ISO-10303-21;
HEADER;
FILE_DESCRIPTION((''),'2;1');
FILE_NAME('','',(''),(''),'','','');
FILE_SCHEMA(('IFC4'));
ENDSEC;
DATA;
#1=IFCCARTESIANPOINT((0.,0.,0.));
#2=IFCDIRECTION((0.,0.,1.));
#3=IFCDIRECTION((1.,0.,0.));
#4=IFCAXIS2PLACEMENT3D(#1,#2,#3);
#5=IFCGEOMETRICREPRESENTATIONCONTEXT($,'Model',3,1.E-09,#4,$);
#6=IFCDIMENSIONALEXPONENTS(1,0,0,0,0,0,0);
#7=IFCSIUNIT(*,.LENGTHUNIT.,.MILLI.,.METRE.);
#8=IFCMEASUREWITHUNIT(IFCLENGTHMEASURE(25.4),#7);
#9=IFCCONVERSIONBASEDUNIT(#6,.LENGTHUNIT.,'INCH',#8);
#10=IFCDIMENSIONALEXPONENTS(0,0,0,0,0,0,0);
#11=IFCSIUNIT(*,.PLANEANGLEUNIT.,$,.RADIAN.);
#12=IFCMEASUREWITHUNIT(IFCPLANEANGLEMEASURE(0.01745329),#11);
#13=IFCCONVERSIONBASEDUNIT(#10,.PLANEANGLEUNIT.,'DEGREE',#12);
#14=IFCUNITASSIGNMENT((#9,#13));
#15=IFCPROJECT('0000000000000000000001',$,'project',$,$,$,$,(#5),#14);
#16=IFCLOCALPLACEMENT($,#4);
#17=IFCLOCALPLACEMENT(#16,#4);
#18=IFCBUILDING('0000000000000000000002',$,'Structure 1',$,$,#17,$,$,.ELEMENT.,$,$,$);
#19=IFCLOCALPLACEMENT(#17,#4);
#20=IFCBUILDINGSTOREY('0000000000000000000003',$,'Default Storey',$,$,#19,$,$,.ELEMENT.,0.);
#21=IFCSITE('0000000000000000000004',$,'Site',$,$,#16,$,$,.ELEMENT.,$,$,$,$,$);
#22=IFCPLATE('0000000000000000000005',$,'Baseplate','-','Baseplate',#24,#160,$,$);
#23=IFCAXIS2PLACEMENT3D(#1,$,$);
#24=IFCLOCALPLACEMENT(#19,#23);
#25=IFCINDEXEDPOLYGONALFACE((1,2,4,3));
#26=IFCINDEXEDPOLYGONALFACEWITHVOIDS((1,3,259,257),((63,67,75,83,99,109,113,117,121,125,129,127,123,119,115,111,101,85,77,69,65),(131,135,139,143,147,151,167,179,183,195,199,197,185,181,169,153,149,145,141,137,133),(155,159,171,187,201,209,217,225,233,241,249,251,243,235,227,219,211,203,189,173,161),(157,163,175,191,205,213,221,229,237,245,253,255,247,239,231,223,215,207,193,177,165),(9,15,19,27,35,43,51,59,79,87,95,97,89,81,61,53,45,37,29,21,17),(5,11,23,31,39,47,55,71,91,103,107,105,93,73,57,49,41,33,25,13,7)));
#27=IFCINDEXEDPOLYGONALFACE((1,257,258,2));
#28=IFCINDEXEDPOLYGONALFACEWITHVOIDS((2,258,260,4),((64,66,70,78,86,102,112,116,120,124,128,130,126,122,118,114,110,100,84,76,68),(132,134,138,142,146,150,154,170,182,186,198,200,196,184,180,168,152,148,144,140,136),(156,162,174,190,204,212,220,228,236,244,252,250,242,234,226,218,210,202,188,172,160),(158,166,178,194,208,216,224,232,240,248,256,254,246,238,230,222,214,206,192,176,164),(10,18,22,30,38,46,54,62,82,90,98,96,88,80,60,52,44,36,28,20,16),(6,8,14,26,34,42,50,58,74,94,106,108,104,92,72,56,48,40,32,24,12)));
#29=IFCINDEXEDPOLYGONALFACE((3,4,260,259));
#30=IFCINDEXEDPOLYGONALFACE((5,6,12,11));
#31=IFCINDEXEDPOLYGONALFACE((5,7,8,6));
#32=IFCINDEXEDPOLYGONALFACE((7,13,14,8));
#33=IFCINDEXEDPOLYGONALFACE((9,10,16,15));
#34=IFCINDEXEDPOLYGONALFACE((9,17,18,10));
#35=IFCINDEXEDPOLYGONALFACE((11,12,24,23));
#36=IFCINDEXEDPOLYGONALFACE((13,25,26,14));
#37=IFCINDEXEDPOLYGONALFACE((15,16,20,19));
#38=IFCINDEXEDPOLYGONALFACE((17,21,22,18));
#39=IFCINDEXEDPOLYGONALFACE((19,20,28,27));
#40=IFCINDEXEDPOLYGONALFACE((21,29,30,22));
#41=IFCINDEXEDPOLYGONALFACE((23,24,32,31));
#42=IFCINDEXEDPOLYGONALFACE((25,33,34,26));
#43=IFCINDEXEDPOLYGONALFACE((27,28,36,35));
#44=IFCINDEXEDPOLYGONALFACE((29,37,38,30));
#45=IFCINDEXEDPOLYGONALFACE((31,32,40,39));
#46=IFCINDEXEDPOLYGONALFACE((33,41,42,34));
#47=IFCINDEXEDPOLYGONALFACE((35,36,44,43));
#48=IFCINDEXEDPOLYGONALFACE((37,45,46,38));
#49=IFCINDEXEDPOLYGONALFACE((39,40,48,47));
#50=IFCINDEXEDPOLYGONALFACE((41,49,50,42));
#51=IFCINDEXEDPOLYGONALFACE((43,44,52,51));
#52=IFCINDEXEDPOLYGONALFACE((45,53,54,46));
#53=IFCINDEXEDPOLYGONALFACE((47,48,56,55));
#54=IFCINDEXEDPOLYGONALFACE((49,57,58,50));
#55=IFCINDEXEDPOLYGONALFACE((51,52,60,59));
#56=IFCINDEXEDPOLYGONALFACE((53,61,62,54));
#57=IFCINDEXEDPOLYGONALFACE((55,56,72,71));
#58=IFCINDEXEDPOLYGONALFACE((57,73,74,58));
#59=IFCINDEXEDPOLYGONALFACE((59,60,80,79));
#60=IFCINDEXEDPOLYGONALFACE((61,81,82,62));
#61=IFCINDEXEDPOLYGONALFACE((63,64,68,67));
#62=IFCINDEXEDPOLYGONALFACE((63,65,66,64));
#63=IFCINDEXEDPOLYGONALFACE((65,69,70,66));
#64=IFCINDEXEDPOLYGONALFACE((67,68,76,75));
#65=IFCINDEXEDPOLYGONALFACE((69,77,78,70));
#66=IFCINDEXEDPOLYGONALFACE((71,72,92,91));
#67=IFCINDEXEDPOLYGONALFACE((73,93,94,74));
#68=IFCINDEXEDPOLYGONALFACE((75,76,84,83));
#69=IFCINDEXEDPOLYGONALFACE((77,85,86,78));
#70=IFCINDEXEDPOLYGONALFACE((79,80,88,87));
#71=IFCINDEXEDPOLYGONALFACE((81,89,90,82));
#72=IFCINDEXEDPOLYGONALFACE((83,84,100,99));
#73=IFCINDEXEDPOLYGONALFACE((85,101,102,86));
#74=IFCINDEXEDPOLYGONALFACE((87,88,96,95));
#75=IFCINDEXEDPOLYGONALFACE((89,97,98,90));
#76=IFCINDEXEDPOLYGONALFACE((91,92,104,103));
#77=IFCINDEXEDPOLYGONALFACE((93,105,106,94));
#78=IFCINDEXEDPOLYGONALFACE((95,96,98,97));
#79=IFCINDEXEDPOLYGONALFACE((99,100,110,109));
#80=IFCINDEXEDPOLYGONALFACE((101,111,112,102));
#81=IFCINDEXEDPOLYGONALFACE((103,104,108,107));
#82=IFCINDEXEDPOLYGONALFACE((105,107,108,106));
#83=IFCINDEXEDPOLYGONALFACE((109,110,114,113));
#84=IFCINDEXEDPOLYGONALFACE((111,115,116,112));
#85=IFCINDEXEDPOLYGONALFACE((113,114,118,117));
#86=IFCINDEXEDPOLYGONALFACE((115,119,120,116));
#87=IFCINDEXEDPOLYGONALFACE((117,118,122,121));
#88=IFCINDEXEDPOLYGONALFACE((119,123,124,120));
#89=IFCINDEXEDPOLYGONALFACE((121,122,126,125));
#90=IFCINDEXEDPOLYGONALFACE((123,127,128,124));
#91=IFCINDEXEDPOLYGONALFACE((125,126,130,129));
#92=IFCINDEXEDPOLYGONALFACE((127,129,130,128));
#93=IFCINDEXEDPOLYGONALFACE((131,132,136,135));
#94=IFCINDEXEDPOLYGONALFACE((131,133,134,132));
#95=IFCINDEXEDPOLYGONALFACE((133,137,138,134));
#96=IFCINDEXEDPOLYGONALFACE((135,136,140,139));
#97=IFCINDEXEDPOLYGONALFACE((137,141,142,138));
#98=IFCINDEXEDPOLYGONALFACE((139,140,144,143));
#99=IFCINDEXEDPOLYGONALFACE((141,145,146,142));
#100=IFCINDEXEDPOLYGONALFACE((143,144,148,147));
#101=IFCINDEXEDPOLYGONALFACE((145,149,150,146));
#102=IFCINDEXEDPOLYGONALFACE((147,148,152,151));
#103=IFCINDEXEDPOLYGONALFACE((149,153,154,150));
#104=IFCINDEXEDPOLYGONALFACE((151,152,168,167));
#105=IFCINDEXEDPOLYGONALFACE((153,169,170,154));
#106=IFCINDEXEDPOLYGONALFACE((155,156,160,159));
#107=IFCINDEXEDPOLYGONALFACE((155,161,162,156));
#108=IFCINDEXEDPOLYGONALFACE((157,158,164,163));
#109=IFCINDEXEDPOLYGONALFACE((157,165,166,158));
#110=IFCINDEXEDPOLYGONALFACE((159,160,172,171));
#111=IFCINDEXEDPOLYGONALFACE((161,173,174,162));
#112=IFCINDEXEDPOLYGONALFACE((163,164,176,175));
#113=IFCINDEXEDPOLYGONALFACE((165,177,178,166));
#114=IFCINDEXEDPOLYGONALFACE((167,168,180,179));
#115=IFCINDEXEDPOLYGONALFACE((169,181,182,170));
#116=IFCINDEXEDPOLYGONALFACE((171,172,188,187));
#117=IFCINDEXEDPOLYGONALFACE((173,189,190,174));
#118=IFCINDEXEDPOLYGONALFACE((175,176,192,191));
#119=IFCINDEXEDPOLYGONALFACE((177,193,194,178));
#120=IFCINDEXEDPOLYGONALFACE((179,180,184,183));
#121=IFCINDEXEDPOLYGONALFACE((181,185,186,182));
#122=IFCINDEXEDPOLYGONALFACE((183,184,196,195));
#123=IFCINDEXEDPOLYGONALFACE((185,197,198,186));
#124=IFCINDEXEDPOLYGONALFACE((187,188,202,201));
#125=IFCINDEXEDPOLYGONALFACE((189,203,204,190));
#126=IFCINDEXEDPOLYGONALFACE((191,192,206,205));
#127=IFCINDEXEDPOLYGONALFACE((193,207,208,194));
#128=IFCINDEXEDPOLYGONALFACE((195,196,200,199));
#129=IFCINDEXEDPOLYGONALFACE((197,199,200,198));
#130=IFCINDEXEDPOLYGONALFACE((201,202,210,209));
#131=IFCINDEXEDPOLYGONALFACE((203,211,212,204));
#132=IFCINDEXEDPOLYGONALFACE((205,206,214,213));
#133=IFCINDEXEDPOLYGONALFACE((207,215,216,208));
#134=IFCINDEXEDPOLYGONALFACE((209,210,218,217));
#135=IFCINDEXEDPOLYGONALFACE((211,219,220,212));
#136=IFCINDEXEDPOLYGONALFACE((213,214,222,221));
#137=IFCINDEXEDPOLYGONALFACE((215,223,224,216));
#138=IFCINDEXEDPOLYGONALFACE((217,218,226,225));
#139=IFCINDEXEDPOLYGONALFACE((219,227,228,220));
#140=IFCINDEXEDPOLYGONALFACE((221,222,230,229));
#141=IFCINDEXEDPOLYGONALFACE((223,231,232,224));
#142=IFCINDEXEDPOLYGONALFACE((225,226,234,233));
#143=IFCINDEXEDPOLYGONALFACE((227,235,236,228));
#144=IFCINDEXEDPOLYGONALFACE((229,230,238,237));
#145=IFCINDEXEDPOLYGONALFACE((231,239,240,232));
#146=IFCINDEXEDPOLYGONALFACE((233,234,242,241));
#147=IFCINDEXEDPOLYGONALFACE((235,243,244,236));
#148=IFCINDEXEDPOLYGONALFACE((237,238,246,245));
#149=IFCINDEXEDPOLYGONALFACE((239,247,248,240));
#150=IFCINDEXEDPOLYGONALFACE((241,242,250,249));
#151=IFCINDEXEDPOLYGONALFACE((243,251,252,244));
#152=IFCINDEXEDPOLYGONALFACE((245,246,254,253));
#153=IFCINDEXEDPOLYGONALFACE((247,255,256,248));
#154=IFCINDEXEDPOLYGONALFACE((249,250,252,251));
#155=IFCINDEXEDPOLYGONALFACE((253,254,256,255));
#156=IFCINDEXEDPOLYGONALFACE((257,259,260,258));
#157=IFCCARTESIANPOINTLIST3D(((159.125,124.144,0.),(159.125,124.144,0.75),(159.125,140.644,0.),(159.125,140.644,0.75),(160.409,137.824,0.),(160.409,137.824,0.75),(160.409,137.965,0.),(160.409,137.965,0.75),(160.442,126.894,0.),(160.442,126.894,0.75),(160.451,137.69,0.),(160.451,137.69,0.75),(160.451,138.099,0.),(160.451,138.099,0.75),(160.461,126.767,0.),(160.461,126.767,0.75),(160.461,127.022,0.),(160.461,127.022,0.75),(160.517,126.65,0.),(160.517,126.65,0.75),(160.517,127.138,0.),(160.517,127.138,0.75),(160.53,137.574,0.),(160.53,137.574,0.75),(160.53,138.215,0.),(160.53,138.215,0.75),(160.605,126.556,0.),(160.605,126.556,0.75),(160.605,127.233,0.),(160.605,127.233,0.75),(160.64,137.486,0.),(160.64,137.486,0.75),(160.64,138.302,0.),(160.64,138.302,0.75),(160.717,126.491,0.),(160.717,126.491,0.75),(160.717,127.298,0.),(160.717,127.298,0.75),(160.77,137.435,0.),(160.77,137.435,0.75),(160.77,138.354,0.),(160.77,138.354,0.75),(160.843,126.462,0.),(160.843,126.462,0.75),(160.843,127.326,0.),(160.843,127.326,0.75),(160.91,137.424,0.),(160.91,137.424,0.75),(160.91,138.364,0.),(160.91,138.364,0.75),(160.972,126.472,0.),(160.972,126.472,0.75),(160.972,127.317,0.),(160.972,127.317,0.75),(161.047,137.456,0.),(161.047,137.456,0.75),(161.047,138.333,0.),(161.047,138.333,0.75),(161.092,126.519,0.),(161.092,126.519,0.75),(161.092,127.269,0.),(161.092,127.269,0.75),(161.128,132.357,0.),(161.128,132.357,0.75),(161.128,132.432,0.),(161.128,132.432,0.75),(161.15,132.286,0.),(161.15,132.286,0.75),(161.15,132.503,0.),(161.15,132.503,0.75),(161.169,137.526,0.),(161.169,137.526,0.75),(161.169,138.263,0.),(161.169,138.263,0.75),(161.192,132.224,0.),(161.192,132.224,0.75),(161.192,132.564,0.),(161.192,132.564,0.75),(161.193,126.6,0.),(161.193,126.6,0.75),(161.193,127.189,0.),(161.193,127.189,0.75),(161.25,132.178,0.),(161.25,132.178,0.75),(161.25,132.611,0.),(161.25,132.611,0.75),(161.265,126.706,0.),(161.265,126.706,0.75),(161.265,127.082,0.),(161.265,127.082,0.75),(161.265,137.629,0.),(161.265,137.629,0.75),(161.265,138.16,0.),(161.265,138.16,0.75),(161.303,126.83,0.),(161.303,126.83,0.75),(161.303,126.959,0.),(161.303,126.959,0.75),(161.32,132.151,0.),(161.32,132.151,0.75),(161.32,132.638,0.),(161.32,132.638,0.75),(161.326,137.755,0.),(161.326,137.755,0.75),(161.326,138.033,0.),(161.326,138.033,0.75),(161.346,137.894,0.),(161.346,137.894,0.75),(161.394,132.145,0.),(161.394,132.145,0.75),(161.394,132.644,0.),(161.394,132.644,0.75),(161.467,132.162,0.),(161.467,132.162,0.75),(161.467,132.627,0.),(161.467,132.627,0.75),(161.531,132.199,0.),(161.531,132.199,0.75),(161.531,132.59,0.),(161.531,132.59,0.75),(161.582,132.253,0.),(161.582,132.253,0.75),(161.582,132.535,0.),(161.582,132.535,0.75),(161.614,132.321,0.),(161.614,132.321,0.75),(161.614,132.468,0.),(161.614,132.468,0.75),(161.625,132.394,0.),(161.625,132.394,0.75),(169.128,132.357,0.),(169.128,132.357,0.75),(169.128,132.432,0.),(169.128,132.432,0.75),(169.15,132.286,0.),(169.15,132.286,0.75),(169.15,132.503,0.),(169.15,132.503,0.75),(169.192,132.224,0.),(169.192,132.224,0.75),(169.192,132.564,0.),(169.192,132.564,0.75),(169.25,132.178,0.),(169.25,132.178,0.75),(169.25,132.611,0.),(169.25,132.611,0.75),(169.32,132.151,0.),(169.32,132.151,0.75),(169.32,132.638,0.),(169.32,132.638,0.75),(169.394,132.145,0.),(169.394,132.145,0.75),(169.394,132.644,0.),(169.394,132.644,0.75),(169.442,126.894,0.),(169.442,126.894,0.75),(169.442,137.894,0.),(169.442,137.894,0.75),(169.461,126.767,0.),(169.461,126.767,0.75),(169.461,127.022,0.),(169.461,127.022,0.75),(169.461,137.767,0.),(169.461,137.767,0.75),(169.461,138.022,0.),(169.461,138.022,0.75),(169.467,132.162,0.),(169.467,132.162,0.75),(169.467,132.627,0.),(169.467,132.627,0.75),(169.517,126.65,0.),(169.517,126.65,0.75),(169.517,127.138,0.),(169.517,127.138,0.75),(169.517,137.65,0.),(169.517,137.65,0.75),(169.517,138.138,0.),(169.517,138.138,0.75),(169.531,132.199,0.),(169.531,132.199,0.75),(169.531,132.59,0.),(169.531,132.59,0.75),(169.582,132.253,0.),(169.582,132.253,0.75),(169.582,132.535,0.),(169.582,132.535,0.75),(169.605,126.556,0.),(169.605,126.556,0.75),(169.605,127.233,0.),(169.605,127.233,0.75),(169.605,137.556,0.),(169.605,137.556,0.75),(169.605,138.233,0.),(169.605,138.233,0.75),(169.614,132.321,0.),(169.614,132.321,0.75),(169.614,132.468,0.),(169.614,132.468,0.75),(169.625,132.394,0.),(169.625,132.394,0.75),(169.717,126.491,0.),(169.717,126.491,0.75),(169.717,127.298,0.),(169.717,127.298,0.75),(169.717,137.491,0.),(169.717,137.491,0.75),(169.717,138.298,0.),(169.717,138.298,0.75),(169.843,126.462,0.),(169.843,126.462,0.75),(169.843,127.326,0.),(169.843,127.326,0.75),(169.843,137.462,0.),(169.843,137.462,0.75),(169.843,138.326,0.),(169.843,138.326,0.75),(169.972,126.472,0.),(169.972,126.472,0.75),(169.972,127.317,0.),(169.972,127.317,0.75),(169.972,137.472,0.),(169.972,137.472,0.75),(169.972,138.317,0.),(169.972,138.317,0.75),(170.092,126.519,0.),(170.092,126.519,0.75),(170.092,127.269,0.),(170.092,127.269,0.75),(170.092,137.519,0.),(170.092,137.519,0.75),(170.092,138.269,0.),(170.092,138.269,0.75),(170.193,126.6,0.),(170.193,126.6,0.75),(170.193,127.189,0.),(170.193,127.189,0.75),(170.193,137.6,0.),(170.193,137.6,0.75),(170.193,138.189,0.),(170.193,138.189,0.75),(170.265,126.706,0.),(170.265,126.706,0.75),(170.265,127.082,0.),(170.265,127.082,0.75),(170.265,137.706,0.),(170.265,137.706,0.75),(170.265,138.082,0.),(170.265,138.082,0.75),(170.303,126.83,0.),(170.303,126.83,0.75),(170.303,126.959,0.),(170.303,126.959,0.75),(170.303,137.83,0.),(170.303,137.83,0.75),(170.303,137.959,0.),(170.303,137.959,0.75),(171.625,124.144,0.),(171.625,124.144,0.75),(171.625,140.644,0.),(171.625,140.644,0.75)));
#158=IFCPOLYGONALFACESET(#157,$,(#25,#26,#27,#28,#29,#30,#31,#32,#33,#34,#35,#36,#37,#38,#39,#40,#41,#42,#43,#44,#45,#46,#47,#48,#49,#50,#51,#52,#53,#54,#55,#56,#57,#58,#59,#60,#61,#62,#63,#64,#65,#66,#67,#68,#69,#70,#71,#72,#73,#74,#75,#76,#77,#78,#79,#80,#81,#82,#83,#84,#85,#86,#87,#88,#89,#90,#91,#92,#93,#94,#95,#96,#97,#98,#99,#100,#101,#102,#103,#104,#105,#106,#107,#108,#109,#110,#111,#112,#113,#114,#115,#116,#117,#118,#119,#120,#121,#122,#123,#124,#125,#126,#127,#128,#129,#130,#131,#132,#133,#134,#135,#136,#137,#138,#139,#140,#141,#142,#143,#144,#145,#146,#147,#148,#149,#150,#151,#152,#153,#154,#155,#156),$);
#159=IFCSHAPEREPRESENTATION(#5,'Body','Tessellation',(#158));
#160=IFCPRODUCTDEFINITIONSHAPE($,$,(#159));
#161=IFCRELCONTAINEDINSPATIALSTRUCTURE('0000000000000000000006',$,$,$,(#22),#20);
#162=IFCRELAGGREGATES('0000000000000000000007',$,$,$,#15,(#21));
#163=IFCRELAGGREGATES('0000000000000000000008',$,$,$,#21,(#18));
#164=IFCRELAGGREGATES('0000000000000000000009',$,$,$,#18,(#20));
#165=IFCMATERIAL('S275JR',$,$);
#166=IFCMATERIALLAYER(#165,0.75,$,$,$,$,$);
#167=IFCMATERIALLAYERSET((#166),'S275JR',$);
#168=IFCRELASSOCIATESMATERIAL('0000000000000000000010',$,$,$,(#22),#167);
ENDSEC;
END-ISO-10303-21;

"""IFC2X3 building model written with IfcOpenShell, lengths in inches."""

from ifc_helpers import new_model, entity, si_unit, converted_unit, frame, frame_2d, origin, origin_with_axes, origin_2d_with_axis, place, context, project, spatial, polyline, circle, outline, extrude, material, layer, layer_set, element, save


model = new_model("IFC2X3")

# Units and contexts
model_context = context("Model", 3, precision=1e-09, world=origin_with_axes())
ifc_project = project(units=[converted_unit("LENGTHUNIT", "INCH", entity("IfcLengthMeasure", 25.4), si_unit("LENGTHUNIT", "METRE", prefix="MILLI"), dimensions=[1, 0, 0, 0, 0, 0, 0]), converted_unit("PLANEANGLEUNIT", "DEGREE", entity("IfcPlaneAngleMeasure", 0.01745329), si_unit("PLANEANGLEUNIT", "RADIAN"), dimensions=[0, 0, 0, 0, 0, 0, 0])], contexts=[model_context])

# Site, building, storey
site_placement = place(None, origin_with_axes())
site = spatial("IfcSite", under=ifc_project, at=site_placement, Name="Site", CompositionType="ELEMENT")
building_placement = place(site_placement, origin_with_axes())
building = spatial("IfcBuilding", under=site, at=building_placement, Name="Structure 1", CompositionType="ELEMENT")
storey_placement = place(building_placement, origin_with_axes())
storey = spatial("IfcBuildingStorey", under=building, at=storey_placement, Name="Default Storey", CompositionType="ELEMENT", Elevation=0.0)

# Plate, openings
ifc_material_1 = material(Name="S275JR")
ifc_layer_1 = layer(ifc_material_1, 0.75)
ifc_layer_set_1 = layer_set([ifc_layer_1], Name="S275JR")
plate_1_placement = place(None, frame((171.625, 124.144, 0.75), z_axis=(0.0, 0.0, -1.0), x_axis=(-1.0, 0.0, 0.0)))
plate_1 = element("IfcPlate", 1, at=plate_1_placement, inside=storey, material=ifc_layer_set_1, Name="Baseplate", Description="-", ObjectType="Baseplate", context=model_context, shape_type="SweptSolid", body=[
    extrude(outline(polyline([(0.0, 0.0), (12.5, 0.0), (12.5, 16.5), (0.0, 16.5), (0.0, 0.0)])), origin_with_axes(), (0.0, 0.0, 1.0), 0.75),
])
opening_1_placement = place(plate_1_placement, frame((1.75, 13.75, 0.77), z_axis=(0.0, 0.0, -1.0), x_axis=(1.0, 0.0, 0.0)))
element("IfcOpeningElement", 2, at=opening_1_placement, cuts=plate_1, ObjectType="Opening", context=model_context, shape_type="SweptSolid", body=[
    extrude(circle(Radius=0.433, at=frame_2d((9.0, 11.0), x_axis=(1.0, 0.0))), origin(), (0.0, 0.0, 1.0), 0.789),
])
opening_2_placement = place(plate_1_placement, frame((1.75, 13.75, 0.77), z_axis=(0.0, 0.0, -1.0), x_axis=(1.0, 0.0, 0.0)))
element("IfcOpeningElement", 3, at=opening_2_placement, cuts=plate_1, ObjectType="Opening", context=model_context, shape_type="SweptSolid", body=[
    extrude(circle(Radius=0.433, at=frame_2d((0.0, 11.0), x_axis=(1.0, 0.0))), origin(), (0.0, 0.0, 1.0), 0.789),
])
opening_3_placement = place(plate_1_placement, frame((1.75, 13.75, 0.77), z_axis=(0.0, 0.0, -1.0), x_axis=(1.0, 0.0, 0.0)))
element("IfcOpeningElement", 4, at=opening_3_placement, cuts=plate_1, ObjectType="Opening", context=model_context, shape_type="SweptSolid", body=[
    extrude(circle(Radius=0.433, at=frame_2d((9.0, 0.0), x_axis=(1.0, 0.0))), origin(), (0.0, 0.0, 1.0), 0.789),
])
opening_4_placement = place(plate_1_placement, frame((1.75, 13.75, 0.77), z_axis=(0.0, 0.0, -1.0), x_axis=(1.0, 0.0, 0.0)))
element("IfcOpeningElement", 5, at=opening_4_placement, cuts=plate_1, ObjectType="Opening", context=model_context, shape_type="SweptSolid", body=[
    extrude(circle(Radius=0.433, at=origin_2d_with_axis()), origin(), (0.0, 0.0, 1.0), 0.789),
])
opening_5_placement = place(plate_1_placement, frame((2.25, 8.25, 0.77), z_axis=(0.0, 0.0, -1.0), x_axis=(-1.0, 0.0, 0.0)))
element("IfcOpeningElement", 6, at=opening_5_placement, cuts=plate_1, ObjectType="Opening", context=model_context, shape_type="SweptSolid", body=[
    extrude(circle(Radius=0.25, at=origin_2d_with_axis()), origin(), (0.0, 0.0, 1.0), 0.789),
])
opening_6_placement = place(plate_1_placement, frame((10.25, 8.25, 0.77), z_axis=(0.0, 0.0, -1.0), x_axis=(-1.0, 0.0, 0.0)))
element("IfcOpeningElement", 7, at=opening_6_placement, cuts=plate_1, ObjectType="Opening", context=model_context, shape_type="SweptSolid", body=[
    extrude(circle(Radius=0.25, at=origin_2d_with_axis()), origin(), (0.0, 0.0, 1.0), 0.789),
])
opening_7_placement = place(plate_1_placement, frame((10.75, 13.75, 0.77), z_axis=(0.0, 0.0, -1.0), x_axis=(-1.0, 0.0, 0.0)))
element("IfcOpeningElement", 8, at=opening_7_placement, cuts=plate_1, ObjectType="Opening", context=model_context, shape_type="SweptSolid", body=[
    extrude(circle(Radius=0.471, at=origin_2d_with_axis()), origin(), (0.0, 0.0, 1.0), 0.789),
])

save(model, "model.ifc")
